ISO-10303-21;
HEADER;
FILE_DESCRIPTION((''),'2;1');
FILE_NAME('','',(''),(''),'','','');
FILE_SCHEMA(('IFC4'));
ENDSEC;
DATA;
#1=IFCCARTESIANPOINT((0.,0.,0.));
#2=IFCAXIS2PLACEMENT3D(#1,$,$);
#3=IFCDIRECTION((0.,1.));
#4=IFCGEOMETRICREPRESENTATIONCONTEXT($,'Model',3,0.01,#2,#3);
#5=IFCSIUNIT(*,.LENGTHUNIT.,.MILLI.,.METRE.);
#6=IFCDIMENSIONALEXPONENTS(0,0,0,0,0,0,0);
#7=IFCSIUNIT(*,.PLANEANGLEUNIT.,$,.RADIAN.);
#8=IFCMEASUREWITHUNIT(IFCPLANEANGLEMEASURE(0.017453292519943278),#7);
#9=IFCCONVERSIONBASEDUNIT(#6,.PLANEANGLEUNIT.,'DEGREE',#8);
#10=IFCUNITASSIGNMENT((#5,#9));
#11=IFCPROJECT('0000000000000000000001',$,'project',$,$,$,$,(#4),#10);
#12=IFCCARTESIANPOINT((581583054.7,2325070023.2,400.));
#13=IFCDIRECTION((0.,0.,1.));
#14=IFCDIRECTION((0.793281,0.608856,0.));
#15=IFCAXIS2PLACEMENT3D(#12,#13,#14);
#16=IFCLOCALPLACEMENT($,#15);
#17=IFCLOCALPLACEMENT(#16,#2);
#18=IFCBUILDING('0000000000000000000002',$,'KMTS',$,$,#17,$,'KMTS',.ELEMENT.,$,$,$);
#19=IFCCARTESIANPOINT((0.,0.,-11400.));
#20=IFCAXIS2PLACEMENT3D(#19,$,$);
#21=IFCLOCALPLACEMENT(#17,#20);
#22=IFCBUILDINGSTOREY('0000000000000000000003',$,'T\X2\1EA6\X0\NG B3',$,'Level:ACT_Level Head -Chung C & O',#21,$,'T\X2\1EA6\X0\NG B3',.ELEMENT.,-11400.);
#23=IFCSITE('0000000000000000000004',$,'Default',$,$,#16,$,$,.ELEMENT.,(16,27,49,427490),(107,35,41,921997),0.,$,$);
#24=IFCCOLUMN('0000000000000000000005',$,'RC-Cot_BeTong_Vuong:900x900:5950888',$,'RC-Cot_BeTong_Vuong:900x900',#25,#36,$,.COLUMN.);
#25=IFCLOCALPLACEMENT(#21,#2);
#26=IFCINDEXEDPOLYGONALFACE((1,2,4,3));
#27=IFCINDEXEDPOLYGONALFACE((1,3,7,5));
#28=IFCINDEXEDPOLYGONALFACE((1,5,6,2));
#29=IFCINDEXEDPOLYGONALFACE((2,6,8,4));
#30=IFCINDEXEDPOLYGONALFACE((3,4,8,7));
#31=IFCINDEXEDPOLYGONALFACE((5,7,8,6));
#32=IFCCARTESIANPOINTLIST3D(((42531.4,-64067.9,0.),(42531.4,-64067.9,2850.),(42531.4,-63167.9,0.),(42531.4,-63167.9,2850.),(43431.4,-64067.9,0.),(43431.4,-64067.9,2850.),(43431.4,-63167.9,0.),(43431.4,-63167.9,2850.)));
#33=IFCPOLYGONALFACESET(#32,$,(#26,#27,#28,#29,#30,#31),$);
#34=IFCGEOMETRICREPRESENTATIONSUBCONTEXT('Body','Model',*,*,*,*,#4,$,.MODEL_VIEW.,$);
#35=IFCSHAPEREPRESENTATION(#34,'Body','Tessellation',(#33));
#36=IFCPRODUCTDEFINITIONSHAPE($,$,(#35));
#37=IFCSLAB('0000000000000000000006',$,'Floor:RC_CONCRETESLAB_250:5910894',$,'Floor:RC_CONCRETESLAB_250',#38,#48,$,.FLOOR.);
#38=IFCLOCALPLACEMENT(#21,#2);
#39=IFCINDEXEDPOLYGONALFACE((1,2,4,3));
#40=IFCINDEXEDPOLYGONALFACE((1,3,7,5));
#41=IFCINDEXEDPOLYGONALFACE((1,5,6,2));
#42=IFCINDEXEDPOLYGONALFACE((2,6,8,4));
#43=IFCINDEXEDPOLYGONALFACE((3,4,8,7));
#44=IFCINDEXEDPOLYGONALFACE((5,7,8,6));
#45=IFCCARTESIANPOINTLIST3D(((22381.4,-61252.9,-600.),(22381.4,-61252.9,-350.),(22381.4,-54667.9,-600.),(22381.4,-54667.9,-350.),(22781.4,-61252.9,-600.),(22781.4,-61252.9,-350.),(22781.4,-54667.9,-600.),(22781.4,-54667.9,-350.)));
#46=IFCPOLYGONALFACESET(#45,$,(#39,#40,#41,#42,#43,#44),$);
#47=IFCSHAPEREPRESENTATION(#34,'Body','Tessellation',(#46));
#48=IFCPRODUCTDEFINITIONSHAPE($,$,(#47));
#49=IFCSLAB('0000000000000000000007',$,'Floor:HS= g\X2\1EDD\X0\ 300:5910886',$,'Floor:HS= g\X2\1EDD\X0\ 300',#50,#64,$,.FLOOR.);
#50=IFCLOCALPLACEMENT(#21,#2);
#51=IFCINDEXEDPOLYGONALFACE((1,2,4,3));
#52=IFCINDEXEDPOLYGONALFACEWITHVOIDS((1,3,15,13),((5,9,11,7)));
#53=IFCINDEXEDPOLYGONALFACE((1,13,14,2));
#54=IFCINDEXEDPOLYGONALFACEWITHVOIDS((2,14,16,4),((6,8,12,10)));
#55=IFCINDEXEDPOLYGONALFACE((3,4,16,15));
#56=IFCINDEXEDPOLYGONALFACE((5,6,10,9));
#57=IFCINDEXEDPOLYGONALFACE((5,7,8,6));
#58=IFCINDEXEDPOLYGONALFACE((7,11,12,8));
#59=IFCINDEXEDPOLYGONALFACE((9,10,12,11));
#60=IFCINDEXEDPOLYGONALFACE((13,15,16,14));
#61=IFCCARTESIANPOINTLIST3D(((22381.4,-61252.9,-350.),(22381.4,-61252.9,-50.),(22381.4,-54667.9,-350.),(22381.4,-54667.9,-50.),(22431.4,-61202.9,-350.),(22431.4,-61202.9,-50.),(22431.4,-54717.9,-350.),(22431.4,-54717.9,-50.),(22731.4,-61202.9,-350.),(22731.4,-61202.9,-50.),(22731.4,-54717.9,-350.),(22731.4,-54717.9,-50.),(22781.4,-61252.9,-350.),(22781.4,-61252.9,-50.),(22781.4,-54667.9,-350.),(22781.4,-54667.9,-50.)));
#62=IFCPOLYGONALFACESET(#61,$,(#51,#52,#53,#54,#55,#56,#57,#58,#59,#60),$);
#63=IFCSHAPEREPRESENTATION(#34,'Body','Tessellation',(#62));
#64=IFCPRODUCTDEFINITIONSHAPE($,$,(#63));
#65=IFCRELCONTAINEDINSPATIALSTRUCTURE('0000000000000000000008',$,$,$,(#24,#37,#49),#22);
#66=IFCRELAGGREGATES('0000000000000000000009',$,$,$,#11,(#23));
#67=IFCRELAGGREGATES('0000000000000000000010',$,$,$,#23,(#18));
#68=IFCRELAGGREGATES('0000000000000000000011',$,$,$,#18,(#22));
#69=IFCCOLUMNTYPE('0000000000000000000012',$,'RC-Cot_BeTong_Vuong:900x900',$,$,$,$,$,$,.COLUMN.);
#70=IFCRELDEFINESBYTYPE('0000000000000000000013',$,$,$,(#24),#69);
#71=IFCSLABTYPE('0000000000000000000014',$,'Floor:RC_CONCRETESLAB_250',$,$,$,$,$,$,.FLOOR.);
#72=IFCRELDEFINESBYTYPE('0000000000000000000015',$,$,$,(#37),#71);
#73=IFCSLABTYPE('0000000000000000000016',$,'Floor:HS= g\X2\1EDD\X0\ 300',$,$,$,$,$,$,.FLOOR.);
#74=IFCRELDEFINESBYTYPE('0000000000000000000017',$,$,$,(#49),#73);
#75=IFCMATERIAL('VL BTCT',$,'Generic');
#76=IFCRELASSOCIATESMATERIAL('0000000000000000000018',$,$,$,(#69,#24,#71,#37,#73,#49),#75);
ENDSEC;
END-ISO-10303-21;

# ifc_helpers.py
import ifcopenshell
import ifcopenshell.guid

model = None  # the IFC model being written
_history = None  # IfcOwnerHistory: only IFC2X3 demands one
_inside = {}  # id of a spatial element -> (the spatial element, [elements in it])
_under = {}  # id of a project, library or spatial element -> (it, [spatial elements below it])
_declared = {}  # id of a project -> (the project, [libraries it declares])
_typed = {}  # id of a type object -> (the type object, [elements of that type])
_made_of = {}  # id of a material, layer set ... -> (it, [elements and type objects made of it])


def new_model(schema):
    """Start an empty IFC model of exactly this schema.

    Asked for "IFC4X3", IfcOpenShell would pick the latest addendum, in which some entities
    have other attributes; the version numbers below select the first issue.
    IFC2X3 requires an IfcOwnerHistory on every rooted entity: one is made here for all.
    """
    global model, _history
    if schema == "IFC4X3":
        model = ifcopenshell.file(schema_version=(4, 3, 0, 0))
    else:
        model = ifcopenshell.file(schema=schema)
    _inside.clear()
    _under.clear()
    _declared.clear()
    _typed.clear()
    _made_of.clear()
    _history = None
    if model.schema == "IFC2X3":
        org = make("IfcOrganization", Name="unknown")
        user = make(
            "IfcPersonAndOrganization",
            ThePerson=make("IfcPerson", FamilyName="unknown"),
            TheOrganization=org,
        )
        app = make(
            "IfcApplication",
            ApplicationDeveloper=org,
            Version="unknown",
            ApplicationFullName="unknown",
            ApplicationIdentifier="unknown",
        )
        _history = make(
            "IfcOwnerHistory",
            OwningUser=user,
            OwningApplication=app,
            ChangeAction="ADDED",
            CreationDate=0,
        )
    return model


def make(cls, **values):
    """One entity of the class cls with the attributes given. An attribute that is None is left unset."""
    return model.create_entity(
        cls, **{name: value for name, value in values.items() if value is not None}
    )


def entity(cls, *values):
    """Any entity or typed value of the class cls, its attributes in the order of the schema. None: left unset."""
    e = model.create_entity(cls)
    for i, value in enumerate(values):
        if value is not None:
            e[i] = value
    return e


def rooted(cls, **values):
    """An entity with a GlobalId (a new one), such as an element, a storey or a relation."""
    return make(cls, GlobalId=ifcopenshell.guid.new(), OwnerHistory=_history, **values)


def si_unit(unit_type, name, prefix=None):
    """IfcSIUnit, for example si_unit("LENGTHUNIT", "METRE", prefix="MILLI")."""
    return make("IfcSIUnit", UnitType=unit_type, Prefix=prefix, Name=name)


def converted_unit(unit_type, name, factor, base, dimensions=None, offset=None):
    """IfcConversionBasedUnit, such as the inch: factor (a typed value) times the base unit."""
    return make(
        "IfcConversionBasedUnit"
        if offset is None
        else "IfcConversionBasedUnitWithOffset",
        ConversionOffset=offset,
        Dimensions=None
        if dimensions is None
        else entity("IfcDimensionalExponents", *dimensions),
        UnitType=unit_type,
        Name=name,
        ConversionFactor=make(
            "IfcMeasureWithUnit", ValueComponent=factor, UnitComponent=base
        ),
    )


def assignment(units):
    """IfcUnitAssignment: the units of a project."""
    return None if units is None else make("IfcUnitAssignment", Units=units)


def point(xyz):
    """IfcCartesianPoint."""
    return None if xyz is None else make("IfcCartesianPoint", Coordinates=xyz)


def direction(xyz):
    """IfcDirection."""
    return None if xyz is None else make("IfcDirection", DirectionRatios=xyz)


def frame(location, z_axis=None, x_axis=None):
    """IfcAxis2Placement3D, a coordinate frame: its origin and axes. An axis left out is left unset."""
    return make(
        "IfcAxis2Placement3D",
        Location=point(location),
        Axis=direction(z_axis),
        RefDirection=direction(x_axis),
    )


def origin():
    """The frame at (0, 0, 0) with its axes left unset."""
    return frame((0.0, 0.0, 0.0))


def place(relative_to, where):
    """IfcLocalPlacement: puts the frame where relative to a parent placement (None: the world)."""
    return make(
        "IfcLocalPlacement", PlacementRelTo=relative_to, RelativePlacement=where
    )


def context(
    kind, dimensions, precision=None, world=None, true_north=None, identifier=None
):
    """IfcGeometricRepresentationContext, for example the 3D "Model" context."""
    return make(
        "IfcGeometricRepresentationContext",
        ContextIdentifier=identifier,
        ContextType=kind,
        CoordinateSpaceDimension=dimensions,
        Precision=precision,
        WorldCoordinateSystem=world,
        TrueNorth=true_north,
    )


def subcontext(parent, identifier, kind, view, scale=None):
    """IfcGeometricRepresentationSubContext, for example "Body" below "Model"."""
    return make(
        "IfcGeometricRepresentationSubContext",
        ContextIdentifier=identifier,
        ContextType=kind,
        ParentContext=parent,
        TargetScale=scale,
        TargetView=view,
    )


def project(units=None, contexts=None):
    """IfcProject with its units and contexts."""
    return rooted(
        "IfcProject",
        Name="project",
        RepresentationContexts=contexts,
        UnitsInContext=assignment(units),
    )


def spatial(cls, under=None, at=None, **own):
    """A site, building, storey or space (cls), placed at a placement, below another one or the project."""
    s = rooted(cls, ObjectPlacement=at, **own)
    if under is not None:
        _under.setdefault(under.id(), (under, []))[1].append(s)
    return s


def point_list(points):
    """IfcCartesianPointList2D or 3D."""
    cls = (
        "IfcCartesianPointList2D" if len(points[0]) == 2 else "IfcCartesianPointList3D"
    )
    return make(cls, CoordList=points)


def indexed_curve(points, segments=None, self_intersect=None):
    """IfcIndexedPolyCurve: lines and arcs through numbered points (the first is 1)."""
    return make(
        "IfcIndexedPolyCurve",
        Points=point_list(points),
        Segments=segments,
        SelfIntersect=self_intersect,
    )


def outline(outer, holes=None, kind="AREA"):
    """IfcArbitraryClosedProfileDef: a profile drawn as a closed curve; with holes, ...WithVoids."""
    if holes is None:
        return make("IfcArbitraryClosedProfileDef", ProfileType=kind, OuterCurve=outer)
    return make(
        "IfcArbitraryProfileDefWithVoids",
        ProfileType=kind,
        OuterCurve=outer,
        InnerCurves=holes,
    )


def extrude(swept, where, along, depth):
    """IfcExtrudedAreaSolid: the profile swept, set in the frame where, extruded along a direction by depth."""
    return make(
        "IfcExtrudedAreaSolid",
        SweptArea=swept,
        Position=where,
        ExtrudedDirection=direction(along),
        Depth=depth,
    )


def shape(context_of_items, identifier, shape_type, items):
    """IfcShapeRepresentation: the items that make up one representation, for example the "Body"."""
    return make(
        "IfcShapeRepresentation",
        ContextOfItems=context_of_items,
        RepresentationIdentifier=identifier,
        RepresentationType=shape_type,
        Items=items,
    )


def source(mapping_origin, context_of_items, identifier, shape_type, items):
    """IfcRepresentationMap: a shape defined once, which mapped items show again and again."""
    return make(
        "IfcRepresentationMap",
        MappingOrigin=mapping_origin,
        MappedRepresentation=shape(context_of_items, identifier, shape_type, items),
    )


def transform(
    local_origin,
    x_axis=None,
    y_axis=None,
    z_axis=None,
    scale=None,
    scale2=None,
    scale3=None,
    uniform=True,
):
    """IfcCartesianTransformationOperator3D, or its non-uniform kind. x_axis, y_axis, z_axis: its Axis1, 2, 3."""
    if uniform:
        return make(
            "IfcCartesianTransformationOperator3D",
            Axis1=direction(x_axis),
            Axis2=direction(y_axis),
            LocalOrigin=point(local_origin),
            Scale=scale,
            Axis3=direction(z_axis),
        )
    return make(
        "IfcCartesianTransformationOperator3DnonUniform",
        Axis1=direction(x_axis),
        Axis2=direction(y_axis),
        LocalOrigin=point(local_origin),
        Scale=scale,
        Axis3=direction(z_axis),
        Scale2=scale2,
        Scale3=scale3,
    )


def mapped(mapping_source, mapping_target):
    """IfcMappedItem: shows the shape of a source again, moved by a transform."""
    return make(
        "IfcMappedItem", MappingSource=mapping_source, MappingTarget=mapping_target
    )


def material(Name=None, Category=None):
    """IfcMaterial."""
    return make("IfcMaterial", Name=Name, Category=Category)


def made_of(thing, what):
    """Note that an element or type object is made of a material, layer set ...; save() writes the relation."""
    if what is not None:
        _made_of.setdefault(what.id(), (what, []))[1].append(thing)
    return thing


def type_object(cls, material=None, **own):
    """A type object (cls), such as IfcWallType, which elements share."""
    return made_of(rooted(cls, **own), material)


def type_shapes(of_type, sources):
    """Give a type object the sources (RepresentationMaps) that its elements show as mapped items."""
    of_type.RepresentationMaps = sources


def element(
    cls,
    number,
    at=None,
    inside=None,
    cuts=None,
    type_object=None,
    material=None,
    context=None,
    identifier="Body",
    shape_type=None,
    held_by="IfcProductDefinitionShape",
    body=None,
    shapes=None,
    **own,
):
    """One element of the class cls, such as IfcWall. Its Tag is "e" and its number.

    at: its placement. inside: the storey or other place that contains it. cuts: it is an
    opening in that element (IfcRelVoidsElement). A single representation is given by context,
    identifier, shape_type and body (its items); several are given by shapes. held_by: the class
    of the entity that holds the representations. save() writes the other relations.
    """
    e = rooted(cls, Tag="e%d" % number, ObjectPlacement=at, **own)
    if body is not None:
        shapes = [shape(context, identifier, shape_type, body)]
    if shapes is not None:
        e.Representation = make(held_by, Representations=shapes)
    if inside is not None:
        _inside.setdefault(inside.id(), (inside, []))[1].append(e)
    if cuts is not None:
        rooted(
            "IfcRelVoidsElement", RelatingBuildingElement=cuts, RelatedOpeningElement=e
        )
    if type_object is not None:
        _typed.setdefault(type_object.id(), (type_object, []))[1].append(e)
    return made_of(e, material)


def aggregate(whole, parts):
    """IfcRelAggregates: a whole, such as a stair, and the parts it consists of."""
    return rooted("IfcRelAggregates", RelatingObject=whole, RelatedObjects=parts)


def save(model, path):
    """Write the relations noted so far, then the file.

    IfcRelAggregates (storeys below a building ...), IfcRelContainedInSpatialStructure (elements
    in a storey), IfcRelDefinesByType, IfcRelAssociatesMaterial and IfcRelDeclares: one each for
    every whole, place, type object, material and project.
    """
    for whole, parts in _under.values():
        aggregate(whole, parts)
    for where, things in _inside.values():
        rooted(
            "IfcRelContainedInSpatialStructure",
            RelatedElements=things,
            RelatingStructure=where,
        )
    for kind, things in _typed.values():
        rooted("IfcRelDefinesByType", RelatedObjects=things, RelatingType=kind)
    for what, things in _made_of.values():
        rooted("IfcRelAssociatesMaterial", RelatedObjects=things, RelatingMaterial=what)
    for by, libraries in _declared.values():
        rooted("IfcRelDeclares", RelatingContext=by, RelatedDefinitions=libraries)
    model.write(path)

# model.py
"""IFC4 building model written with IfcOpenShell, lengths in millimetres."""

from ifc_helpers import new_model, entity, si_unit, converted_unit, direction, frame, origin, place, context, subcontext, project, spatial, indexed_curve, outline, extrude, source, transform, mapped, material, type_object, type_shapes, element, save


model = new_model("IFC4")

# Units and contexts
model_context = context("Model", 3, precision=0.01, world=origin(), true_north=direction((0.0, 1.0)))
body_context = subcontext(model_context, "Body", "Model", "MODEL_VIEW")
ifc_project = project(units=[si_unit("LENGTHUNIT", "METRE", prefix="MILLI"), converted_unit("PLANEANGLEUNIT", "DEGREE", entity("IfcPlaneAngleMeasure", 0.017453292519943278), si_unit("PLANEANGLEUNIT", "RADIAN"), dimensions=[0, 0, 0, 0, 0, 0, 0])], contexts=[model_context])

# Site, building, storey
site_placement = place(None, frame((581583054.7, 2325070023.2, 400.0), z_axis=(0.0, 0.0, 1.0), x_axis=(0.793281, 0.608856, 0.0)))
site = spatial("IfcSite", under=ifc_project, at=site_placement, Name="Default", CompositionType="ELEMENT", RefLatitude=(16, 27, 49, 427490), RefLongitude=(107, 35, 41, 921997), RefElevation=0.0)
building_placement = place(site_placement, origin())
building = spatial("IfcBuilding", under=site, at=building_placement, Name="KMTS", LongName="KMTS", CompositionType="ELEMENT")
storey_placement = place(building_placement, frame((0.0, 0.0, -11400.0)))
storey = spatial("IfcBuildingStorey", under=building, at=storey_placement, Name="TẦNG B3", ObjectType="Level:ACT_Level Head -Chung C & O", LongName="TẦNG B3", CompositionType="ELEMENT", Elevation=-11400.0)

# Column
ifc_material = material(Name="VL BTCT", Category="Generic")
column_type_1 = type_object("IfcColumnType", Name="RC-Cot_BeTong_Vuong:900x900", PredefinedType="COLUMN", material=ifc_material)
shared_shape_1 = source(origin(), body_context, "Body", "SweptSolid", [
    extrude(outline(indexed_curve([(-450.0, -450.0), (450.0, -450.0), (450.0, 450.0), (-450.0, 450.0), (-450.0, -450.0)], self_intersect=False)), frame((42981.4, -63617.9, -11400.0), z_axis=(0.0, 0.0, 1.0), x_axis=(-1.0, 0.0, 0.0)), (0.0, 0.0, 1.0), 2850.0),
])
type_shapes(column_type_1, [shared_shape_1])
column_1_placement = place(storey_placement, frame((0.0, 0.0, 11400.0)))
element("IfcColumn", 1, at=column_1_placement, inside=storey, type_object=column_type_1, material=ifc_material, Name="RC-Cot_BeTong_Vuong:900x900:5950888", ObjectType="RC-Cot_BeTong_Vuong:900x900", PredefinedType="COLUMN", context=body_context, shape_type="MappedRepresentation", body=[
    mapped(shared_shape_1, transform((0.0, 0.0, 0.0), scale=1.0)),
])

# Slab
slab_type_1 = type_object("IfcSlabType", Name="Floor:RC_CONCRETESLAB_250", PredefinedType="FLOOR", material=ifc_material)
slab_1_placement = place(storey_placement, origin())
element("IfcSlab", 2, at=slab_1_placement, inside=storey, type_object=slab_type_1, material=ifc_material, Name="Floor:RC_CONCRETESLAB_250:5910894", ObjectType="Floor:RC_CONCRETESLAB_250", PredefinedType="FLOOR", context=body_context, shape_type="SweptSolid", body=[
    extrude(outline(indexed_curve([(-3292.5, -200.0), (3292.5, -200.0), (3292.5, 200.0), (-3292.5, 200.0), (-3292.5, -200.0)], self_intersect=False)), frame((22581.4, -57960.4, -350.0), z_axis=(0.0, 0.0, -1.0), x_axis=(0.0, 1.0, 0.0)), (0.0, 0.0, 1.0), 250.0),
])

# Slab, opening
slab_type_2 = type_object("IfcSlabType", Name="Floor:HS= gờ 300", PredefinedType="FLOOR", material=ifc_material)
slab_2_placement = place(storey_placement, origin())
slab_2 = element("IfcSlab", 3, at=slab_2_placement, inside=storey, type_object=slab_type_2, material=ifc_material, Name="Floor:HS= gờ 300:5910886", ObjectType="Floor:HS= gờ 300", PredefinedType="FLOOR", context=body_context, shape_type="SweptSolid", body=[
    extrude(outline(indexed_curve([(-3292.5, -200.0), (3292.5, -200.0), (3292.5, 200.0), (-3292.5, 200.0), (-3292.5, -200.0)], self_intersect=False), holes=[indexed_curve([(-3242.5, -150.0), (-3242.5, 150.0), (3242.5, 150.0), (3242.5, -150.0), (-3242.5, -150.0)], self_intersect=False)]), frame((22581.4, -57960.4, -350.0), z_axis=(0.0, 0.0, 1.0), x_axis=(0.0, -1.0, 0.0)), (0.0, 0.0, 1.0), 300.0),
])
opening_1_placement = place(slab_2_placement, origin())
element("IfcOpeningElement", 4, at=opening_1_placement, cuts=slab_2, PredefinedType="OPENING", context=body_context, shape_type="SweptSolid", body=[
    extrude(outline(indexed_curve([(-150.0, -3242.5), (150.0, -3242.5), (150.0, 3242.5), (-150.0, 3242.5), (-150.0, -3242.5)], self_intersect=False)), frame((22581.4, -57960.4, -50.0), z_axis=(0.0, 0.0, -1.0), x_axis=(1.0, 0.0, 0.0)), (0.0, 0.0, 1.0), 400.0),
])

save(model, "model.ifc")
